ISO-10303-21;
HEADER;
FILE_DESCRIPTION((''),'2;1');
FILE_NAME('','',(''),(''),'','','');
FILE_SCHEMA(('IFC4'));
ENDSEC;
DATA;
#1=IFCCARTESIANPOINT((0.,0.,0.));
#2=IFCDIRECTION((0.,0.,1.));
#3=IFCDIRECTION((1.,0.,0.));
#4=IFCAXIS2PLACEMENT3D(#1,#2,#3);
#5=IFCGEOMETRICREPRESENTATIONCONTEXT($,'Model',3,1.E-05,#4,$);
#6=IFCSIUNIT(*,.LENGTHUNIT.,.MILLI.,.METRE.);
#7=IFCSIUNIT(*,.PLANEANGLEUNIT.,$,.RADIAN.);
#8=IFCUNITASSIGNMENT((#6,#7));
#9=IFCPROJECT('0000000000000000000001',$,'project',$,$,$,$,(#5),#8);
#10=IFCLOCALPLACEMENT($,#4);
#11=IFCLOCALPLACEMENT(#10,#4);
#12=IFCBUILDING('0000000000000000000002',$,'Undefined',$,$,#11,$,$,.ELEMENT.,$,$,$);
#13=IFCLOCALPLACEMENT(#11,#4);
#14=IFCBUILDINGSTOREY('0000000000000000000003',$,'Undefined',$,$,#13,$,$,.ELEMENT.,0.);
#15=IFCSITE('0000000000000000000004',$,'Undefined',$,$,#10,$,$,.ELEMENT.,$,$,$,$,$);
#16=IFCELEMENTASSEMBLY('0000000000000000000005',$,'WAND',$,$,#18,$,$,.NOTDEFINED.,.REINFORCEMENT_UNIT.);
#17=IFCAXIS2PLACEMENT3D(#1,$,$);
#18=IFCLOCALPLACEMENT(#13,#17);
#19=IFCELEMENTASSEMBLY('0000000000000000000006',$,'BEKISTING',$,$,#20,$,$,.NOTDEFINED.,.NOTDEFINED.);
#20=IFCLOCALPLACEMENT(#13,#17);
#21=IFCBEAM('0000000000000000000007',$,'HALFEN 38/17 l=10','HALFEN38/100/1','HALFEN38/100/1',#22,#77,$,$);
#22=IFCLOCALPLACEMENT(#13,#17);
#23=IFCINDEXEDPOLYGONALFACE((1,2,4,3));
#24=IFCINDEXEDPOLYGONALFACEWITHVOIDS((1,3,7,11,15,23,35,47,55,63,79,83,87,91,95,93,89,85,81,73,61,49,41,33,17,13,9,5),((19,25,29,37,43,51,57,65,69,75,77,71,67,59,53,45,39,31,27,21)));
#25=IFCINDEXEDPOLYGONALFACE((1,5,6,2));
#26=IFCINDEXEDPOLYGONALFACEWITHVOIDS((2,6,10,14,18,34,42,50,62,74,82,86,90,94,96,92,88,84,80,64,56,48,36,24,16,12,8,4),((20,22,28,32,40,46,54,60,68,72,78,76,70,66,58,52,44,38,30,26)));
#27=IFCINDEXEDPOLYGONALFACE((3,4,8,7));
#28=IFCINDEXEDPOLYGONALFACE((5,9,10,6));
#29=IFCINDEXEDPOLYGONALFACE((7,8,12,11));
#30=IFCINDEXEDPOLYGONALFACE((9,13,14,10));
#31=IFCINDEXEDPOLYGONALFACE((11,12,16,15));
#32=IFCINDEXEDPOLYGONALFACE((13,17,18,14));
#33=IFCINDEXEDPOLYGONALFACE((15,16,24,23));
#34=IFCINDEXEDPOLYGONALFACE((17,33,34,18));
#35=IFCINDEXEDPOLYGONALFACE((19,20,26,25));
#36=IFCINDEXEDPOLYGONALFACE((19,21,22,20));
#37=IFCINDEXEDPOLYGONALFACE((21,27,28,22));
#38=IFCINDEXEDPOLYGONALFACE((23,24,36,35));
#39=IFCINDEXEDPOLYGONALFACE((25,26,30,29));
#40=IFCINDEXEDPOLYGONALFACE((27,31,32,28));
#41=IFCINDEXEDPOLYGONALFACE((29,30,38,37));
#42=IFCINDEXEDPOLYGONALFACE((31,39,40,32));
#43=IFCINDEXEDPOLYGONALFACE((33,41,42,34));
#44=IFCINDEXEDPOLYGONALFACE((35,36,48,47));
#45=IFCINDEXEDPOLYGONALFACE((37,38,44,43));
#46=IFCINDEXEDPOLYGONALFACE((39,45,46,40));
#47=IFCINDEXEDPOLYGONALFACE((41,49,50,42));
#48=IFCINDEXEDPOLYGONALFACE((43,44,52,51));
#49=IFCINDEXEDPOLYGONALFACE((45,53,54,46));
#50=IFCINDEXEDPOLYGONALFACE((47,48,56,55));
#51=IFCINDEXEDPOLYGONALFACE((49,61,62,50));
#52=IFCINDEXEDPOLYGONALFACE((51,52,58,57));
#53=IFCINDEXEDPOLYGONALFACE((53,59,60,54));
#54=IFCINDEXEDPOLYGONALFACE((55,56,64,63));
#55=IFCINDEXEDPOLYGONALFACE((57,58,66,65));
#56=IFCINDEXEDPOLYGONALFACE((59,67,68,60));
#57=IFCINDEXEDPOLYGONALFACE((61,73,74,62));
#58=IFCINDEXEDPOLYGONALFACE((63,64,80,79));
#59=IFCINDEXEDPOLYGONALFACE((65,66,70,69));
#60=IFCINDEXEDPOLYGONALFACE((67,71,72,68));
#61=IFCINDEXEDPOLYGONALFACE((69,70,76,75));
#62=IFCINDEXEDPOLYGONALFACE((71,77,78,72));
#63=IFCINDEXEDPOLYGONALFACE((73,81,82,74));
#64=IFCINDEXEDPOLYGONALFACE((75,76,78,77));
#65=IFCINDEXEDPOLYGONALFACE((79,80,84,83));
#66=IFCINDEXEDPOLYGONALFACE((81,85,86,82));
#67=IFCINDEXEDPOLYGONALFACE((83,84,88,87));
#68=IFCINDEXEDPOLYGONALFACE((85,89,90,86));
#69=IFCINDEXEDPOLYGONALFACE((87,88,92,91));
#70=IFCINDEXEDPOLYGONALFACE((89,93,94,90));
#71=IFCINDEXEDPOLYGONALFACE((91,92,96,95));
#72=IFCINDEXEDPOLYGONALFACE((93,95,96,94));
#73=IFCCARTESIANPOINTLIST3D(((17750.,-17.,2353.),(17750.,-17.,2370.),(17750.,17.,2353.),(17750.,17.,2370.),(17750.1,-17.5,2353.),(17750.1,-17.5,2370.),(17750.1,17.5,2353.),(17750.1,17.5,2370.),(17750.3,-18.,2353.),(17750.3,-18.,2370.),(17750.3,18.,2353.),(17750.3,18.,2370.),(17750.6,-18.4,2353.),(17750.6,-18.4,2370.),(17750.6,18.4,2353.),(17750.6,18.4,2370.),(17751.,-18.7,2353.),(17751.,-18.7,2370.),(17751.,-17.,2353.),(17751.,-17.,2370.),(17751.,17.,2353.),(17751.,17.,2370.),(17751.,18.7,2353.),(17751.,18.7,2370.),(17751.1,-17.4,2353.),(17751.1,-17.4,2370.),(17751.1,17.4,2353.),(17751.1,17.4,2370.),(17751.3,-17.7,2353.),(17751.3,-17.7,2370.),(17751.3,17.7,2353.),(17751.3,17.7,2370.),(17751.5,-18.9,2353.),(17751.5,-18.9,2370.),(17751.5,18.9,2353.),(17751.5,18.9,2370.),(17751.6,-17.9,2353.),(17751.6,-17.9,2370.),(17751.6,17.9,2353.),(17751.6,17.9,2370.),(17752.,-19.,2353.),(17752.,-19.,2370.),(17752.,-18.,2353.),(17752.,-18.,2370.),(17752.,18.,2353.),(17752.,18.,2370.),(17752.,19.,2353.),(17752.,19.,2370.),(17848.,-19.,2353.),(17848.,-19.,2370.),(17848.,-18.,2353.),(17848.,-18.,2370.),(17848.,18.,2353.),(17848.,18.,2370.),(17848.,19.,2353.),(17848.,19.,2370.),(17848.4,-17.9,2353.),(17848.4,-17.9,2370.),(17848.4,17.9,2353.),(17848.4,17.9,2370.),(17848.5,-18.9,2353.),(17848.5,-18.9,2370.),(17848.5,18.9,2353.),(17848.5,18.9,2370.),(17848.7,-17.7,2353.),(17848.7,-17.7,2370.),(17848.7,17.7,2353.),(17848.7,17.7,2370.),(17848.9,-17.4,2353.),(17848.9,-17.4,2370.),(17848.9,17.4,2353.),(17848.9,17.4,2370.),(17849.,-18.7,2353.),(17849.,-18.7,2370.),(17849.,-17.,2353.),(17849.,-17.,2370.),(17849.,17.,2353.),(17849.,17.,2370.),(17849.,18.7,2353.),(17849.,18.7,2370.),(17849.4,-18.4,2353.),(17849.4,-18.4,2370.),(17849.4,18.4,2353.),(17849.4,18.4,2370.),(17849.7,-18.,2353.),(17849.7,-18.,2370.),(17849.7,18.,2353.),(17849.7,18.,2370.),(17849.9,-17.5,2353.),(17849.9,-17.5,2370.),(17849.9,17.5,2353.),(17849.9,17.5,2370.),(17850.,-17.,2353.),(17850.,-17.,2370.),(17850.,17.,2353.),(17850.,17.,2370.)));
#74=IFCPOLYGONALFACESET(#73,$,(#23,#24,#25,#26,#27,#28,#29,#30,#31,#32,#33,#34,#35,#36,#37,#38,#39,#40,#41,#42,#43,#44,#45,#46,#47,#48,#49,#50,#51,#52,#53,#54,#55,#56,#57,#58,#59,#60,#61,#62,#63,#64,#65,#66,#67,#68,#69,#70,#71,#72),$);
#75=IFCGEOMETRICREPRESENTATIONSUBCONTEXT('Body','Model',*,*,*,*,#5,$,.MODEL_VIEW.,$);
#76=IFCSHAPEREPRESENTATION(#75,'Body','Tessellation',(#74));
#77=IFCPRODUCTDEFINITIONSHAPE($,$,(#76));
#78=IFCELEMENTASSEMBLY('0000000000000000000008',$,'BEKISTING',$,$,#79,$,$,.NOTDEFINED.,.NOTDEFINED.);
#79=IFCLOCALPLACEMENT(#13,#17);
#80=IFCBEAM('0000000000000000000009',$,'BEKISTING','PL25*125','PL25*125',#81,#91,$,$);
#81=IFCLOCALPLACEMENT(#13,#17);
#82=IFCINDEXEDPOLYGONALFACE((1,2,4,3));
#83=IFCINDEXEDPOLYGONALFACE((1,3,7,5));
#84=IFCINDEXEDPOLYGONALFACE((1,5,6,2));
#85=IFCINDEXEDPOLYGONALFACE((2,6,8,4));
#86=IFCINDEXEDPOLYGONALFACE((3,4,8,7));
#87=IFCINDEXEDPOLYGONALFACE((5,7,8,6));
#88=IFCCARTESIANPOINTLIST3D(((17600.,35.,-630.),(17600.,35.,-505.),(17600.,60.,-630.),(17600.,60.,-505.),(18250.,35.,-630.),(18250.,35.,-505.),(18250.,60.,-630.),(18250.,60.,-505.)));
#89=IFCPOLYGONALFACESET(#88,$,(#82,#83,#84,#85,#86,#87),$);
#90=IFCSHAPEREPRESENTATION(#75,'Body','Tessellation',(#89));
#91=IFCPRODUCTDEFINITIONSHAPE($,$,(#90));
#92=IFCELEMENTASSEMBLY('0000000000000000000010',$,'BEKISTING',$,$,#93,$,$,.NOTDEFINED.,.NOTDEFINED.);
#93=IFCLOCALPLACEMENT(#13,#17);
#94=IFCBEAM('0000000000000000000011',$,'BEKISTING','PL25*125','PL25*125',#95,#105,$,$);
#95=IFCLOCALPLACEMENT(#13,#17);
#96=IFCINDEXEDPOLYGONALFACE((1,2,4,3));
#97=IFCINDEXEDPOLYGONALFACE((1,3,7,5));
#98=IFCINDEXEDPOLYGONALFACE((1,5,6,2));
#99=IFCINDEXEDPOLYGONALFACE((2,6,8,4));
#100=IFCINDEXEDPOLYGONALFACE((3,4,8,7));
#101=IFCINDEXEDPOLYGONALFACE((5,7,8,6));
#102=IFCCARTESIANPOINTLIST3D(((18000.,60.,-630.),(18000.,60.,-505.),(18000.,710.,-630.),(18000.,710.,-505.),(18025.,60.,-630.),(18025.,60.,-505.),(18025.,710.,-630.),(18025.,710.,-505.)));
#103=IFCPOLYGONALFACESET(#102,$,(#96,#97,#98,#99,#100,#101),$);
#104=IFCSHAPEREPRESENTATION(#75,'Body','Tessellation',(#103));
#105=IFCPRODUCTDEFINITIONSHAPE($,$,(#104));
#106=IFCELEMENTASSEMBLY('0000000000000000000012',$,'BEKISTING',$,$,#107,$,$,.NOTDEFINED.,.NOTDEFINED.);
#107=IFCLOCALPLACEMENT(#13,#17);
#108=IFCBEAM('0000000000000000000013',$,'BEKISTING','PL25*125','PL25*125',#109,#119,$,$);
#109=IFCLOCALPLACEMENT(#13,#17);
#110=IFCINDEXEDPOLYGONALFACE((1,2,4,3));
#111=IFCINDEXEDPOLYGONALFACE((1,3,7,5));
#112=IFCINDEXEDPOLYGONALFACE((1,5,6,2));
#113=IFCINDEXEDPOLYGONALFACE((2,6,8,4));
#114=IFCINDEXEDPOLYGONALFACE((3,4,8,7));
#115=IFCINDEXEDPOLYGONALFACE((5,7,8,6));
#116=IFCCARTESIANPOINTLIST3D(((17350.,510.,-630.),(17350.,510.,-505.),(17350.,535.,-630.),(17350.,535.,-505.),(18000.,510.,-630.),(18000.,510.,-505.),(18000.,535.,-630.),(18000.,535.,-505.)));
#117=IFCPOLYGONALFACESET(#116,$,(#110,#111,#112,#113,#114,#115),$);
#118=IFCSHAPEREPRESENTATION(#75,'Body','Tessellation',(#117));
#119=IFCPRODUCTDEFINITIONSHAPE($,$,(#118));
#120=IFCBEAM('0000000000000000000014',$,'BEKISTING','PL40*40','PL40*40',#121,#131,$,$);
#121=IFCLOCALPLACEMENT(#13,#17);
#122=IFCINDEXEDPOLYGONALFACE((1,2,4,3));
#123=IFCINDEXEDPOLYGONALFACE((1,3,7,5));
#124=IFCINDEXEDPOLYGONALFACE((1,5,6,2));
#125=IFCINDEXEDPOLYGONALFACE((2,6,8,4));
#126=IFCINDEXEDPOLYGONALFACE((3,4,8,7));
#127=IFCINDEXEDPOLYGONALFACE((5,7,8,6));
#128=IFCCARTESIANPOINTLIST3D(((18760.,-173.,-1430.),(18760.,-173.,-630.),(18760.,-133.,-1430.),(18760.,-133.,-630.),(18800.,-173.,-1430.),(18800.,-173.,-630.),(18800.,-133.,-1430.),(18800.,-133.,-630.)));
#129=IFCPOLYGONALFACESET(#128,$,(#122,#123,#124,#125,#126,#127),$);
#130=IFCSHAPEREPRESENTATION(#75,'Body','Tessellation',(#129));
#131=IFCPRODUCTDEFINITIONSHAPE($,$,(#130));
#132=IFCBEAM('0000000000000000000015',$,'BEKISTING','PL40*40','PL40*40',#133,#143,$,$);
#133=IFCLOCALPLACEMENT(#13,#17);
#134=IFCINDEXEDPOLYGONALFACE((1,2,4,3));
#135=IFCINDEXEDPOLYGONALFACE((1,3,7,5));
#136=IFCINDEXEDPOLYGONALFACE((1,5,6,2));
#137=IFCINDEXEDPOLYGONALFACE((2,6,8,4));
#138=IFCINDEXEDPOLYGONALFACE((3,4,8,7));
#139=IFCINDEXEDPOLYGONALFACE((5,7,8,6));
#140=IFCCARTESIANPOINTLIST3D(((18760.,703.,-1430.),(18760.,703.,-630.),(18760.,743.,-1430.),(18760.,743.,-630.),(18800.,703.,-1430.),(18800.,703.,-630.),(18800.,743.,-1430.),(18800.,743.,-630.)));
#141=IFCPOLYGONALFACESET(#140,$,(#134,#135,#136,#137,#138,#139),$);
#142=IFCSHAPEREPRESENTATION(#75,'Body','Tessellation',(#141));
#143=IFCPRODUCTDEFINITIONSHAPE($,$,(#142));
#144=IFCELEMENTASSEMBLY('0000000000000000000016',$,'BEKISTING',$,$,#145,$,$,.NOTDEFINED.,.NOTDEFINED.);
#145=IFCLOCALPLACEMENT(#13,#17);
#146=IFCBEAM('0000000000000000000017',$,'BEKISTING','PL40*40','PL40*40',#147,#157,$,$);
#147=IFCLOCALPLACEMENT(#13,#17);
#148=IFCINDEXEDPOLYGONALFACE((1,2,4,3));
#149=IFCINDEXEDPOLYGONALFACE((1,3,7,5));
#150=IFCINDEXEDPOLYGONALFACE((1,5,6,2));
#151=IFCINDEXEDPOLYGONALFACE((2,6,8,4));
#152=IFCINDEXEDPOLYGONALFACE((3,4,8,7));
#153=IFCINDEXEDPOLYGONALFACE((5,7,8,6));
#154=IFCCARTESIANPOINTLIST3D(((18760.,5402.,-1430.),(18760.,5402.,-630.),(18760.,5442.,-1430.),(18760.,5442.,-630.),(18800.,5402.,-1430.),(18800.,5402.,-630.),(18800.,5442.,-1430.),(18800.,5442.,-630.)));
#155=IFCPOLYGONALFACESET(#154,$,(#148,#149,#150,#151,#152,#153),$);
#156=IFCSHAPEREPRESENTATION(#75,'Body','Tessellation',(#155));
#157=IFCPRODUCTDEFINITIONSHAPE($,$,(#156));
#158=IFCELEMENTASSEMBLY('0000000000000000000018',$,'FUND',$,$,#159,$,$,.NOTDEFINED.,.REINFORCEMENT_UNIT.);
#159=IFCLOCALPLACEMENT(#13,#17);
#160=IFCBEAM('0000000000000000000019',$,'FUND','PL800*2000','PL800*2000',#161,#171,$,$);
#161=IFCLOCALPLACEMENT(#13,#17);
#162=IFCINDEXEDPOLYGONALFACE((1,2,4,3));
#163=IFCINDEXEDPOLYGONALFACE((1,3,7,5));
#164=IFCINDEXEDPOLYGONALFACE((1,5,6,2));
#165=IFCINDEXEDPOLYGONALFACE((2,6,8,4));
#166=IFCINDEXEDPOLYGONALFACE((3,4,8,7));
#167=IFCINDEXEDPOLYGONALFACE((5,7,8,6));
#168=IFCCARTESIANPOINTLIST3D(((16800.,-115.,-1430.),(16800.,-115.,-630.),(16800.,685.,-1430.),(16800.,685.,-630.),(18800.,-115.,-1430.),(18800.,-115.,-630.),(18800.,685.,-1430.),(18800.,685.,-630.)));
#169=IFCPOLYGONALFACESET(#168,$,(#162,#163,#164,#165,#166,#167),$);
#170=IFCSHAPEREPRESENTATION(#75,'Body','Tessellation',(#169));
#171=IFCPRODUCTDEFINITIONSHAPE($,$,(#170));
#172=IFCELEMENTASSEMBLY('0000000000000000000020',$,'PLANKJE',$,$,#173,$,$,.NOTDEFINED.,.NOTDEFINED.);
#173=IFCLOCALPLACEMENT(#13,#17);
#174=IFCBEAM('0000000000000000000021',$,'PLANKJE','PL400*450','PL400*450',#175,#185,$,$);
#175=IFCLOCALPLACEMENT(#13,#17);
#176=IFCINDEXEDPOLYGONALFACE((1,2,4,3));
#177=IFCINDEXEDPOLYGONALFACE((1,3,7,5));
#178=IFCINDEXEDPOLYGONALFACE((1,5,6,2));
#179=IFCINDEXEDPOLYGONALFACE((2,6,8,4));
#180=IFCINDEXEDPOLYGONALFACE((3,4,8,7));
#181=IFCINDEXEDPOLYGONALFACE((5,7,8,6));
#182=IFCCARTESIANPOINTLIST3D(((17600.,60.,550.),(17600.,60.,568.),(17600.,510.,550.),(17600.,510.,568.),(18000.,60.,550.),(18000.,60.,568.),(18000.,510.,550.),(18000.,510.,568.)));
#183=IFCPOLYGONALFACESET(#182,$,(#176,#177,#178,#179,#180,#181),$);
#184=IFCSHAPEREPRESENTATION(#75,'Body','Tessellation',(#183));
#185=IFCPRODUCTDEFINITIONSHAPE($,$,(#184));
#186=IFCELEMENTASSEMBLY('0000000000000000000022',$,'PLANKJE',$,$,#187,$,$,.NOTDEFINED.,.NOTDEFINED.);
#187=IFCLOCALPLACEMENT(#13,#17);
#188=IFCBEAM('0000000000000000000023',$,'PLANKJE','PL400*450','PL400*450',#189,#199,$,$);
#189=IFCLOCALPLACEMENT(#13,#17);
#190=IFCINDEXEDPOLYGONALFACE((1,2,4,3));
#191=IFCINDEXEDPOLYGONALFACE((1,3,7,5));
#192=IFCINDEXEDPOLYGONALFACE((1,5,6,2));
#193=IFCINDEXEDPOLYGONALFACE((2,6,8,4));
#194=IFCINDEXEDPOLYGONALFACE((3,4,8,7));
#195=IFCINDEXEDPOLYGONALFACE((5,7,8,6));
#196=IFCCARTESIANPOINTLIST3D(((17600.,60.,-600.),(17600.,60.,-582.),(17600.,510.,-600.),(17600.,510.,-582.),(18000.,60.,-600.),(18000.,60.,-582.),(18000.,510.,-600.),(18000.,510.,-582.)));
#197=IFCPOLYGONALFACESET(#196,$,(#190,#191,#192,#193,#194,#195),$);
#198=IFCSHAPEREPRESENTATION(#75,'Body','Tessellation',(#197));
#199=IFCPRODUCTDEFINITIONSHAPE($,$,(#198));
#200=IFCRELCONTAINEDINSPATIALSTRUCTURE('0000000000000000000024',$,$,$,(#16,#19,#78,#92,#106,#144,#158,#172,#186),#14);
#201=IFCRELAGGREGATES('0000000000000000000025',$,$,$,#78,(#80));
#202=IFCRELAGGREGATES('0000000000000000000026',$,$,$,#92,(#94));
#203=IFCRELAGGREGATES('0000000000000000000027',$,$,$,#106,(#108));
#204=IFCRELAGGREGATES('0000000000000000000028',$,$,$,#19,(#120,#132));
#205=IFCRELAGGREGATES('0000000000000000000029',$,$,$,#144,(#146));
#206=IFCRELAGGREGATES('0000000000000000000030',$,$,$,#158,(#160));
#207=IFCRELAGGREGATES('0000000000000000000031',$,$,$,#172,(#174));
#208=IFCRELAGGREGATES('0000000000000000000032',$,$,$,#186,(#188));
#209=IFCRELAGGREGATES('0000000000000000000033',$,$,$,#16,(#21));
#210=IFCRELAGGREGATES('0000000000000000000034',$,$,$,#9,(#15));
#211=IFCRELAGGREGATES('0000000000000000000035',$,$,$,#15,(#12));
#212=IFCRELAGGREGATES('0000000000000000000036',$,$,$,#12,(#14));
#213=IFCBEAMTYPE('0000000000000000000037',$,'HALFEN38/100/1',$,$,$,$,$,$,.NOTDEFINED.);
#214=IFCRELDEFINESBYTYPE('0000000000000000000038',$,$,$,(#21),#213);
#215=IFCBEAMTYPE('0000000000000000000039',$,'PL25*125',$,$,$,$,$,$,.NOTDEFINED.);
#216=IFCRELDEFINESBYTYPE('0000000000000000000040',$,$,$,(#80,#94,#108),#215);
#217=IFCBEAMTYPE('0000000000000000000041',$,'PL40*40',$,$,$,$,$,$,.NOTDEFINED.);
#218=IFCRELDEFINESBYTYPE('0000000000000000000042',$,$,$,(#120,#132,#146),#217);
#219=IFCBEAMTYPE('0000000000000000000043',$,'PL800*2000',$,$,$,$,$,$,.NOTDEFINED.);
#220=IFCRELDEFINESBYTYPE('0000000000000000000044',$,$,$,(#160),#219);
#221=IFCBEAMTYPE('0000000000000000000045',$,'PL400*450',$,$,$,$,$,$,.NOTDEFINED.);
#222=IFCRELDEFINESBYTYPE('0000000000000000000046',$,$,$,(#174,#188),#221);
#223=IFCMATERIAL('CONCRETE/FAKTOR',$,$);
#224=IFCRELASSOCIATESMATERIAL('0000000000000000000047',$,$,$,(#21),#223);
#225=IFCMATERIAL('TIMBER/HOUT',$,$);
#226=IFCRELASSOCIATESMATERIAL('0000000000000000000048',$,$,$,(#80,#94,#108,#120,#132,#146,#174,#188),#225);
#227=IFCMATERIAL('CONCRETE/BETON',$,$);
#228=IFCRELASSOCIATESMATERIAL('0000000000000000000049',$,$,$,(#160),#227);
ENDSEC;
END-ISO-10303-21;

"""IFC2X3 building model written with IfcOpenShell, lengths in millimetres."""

from ifc_helpers import new_model, si_unit, frame, frame_2d, origin_with_axes, place, context, subcontext, project, spatial, rectangle, hollow_rectangle, extrude, material, type_object, element, aggregate, save


model = new_model("IFC2X3")

# Units and contexts
model_context = context("Model", 3, precision=1e-05, world=origin_with_axes())
body_context = subcontext(model_context, "Body", "Model", "MODEL_VIEW")
ifc_project = project(units=[si_unit("LENGTHUNIT", "METRE", prefix="MILLI"), si_unit("PLANEANGLEUNIT", "RADIAN")], contexts=[model_context])

# Site, building, storey
site_placement = place(None, origin_with_axes())
site = spatial("IfcSite", under=ifc_project, at=site_placement, Name="Undefined", CompositionType="ELEMENT")
building_placement = place(site_placement, origin_with_axes())
building = spatial("IfcBuilding", under=site, at=building_placement, Name="Undefined", CompositionType="ELEMENT")
storey_placement = place(building_placement, origin_with_axes())
storey = spatial("IfcBuildingStorey", under=building, at=storey_placement, Name="Undefined", CompositionType="ELEMENT", Elevation=0.0)

# Element assembly
ifc_material_1 = material(Name="CONCRETE/FAKTOR")
assembly_1_placement = place(storey_placement, origin_with_axes())
assembly_1 = element("IfcElementAssembly", 1, at=assembly_1_placement, inside=storey, Name="WAND", AssemblyPlace="NOTDEFINED", PredefinedType="REINFORCEMENT_UNIT")
ifc_material_2 = material(Name="CONCRETE/BETON")

# Element assembly
ifc_material_3 = material(Name="TIMBER/HOUT")
assembly_2_placement = place(storey_placement, origin_with_axes())
assembly_2 = element("IfcElementAssembly", 2, at=assembly_2_placement, inside=storey, Name="BEKISTING", AssemblyPlace="NOTDEFINED", PredefinedType="NOTDEFINED")

# Beam
beam_type_1 = type_object("IfcBeamType", Name="HALFEN38/100/1", PredefinedType="NOTDEFINED")
beam_1_placement = place(assembly_1_placement, frame((17800.0, 0.0, 2370.0), z_axis=(0.0, -1.0, 0.0), x_axis=(0.0, 0.0, -1.0)))
beam_1 = element("IfcBeam", 3, at=beam_1_placement, type_object=beam_type_1, material=ifc_material_1, Name="HALFEN 38/17 l=10", Description="HALFEN38/100/1", ObjectType="HALFEN38/100/1", context=body_context, shape_type="SweptSolid", body=[
    extrude(hollow_rectangle(XDim=100.0, YDim=38.0, WallThickness=1.0, InnerFilletRadius=1.0, OuterFilletRadius=2.0, at=frame_2d((0.0, 0.0), x_axis=(1.0, 0.0))), frame((17.0, 0.0, 0.0), z_axis=(-1.0, 0.0, 0.0), x_axis=(0.0, -1.0, 0.0)), (0.0, 0.0, 1.0), 17.0),
])

# Element assemblies, beams
assembly_3_placement = place(storey_placement, origin_with_axes())
assembly_3 = element("IfcElementAssembly", 4, at=assembly_3_placement, inside=storey, Name="BEKISTING", AssemblyPlace="NOTDEFINED", PredefinedType="NOTDEFINED")
beam_type_2 = type_object("IfcBeamType", Name="PL25*125", PredefinedType="NOTDEFINED")
beam_2_placement = place(assembly_3_placement, frame((18250.0, 47.5, -567.5), z_axis=(0.0, 0.0, -1.0), x_axis=(-1.0, 0.0, 0.0)))
beam_2 = element("IfcBeam", 5, at=beam_2_placement, type_object=beam_type_2, material=ifc_material_3, Name="BEKISTING", Description="PL25*125", ObjectType="PL25*125", context=body_context, shape_type="SweptSolid", body=[
    extrude(rectangle(XDim=25.0, YDim=125.0, at=frame_2d((0.0, 0.0), x_axis=(1.0, 0.0))), frame((650.0, 0.0, 0.0), z_axis=(-1.0, 0.0, 0.0), x_axis=(0.0, -1.0, 0.0)), (0.0, 0.0, 1.0), 650.0),
])
aggregate(assembly_3, [beam_2])
assembly_4_placement = place(storey_placement, origin_with_axes())
assembly_4 = element("IfcElementAssembly", 6, at=assembly_4_placement, inside=storey, Name="BEKISTING", AssemblyPlace="NOTDEFINED", PredefinedType="NOTDEFINED")
beam_3_placement = place(assembly_4_placement, frame((18012.5, 60.0, -567.5), z_axis=(0.0, 0.0, -1.0), x_axis=(0.0, 1.0, 0.0)))
beam_3 = element("IfcBeam", 7, at=beam_3_placement, type_object=beam_type_2, material=ifc_material_3, Name="BEKISTING", Description="PL25*125", ObjectType="PL25*125", context=body_context, shape_type="SweptSolid", body=[
    extrude(rectangle(XDim=25.0, YDim=125.0, at=frame_2d((0.0, 0.0), x_axis=(1.0, 0.0))), frame((650.0, 0.0, 0.0), z_axis=(-1.0, 0.0, 0.0), x_axis=(0.0, -1.0, 0.0)), (0.0, 0.0, 1.0), 650.0),
])
aggregate(assembly_4, [beam_3])
assembly_5_placement = place(storey_placement, origin_with_axes())
assembly_5 = element("IfcElementAssembly", 8, at=assembly_5_placement, inside=storey, Name="BEKISTING", AssemblyPlace="NOTDEFINED", PredefinedType="NOTDEFINED")
beam_4_placement = place(assembly_5_placement, frame((18000.0, 522.5, -567.5), z_axis=(0.0, 0.0, -1.0), x_axis=(-1.0, 0.0, 0.0)))
beam_4 = element("IfcBeam", 9, at=beam_4_placement, type_object=beam_type_2, material=ifc_material_3, Name="BEKISTING", Description="PL25*125", ObjectType="PL25*125", context=body_context, shape_type="SweptSolid", body=[
    extrude(rectangle(XDim=25.0, YDim=125.0, at=frame_2d((0.0, 0.0), x_axis=(1.0, 0.0))), frame((650.0, 0.0, 0.0), z_axis=(-1.0, 0.0, 0.0), x_axis=(0.0, -1.0, 0.0)), (0.0, 0.0, 1.0), 650.0),
])
aggregate(assembly_5, [beam_4])

# Beams
beam_type_3 = type_object("IfcBeamType", Name="PL40*40", PredefinedType="NOTDEFINED")
beam_5_placement = place(assembly_2_placement, frame((18780.0, -153.0, -1430.0), z_axis=(0.0, 1.0, 0.0), x_axis=(0.0, 0.0, 1.0)))
beam_5 = element("IfcBeam", 10, at=beam_5_placement, type_object=beam_type_3, material=ifc_material_3, Name="BEKISTING", Description="PL40*40", ObjectType="PL40*40", context=body_context, shape_type="SweptSolid", body=[
    extrude(rectangle(XDim=40.0, YDim=40.0, at=frame_2d((0.0, 0.0), x_axis=(1.0, 0.0))), frame((800.0, 0.0, 0.0), z_axis=(-1.0, 0.0, 0.0), x_axis=(0.0, -1.0, 0.0)), (0.0, 0.0, 1.0), 800.0),
])
beam_6_placement = place(assembly_2_placement, frame((18780.0, 723.0, -1430.0), z_axis=(0.0, 1.0, 0.0), x_axis=(0.0, 0.0, 1.0)))
beam_6 = element("IfcBeam", 11, at=beam_6_placement, type_object=beam_type_3, material=ifc_material_3, Name="BEKISTING", Description="PL40*40", ObjectType="PL40*40", context=body_context, shape_type="SweptSolid", body=[
    extrude(rectangle(XDim=40.0, YDim=40.0, at=frame_2d((0.0, 0.0), x_axis=(1.0, 0.0))), frame((800.0, 0.0, 0.0), z_axis=(-1.0, 0.0, 0.0), x_axis=(0.0, -1.0, 0.0)), (0.0, 0.0, 1.0), 800.0),
])
aggregate(assembly_2, [beam_5, beam_6])

# Element assemblies, beams
assembly_6_placement = place(storey_placement, origin_with_axes())
assembly_6 = element("IfcElementAssembly", 12, at=assembly_6_placement, inside=storey, Name="BEKISTING", AssemblyPlace="NOTDEFINED", PredefinedType="NOTDEFINED")
beam_7_placement = place(assembly_6_placement, frame((18780.0, 5422.0, -1430.0), z_axis=(0.0, 1.0, 0.0), x_axis=(0.0, 0.0, 1.0)))
beam_7 = element("IfcBeam", 13, at=beam_7_placement, type_object=beam_type_3, material=ifc_material_3, Name="BEKISTING", Description="PL40*40", ObjectType="PL40*40", context=body_context, shape_type="SweptSolid", body=[
    extrude(rectangle(XDim=40.0, YDim=40.0, at=frame_2d((0.0, 0.0), x_axis=(1.0, 0.0))), frame((800.0, 0.0, 0.0), z_axis=(-1.0, 0.0, 0.0), x_axis=(0.0, -1.0, 0.0)), (0.0, 0.0, 1.0), 800.0),
])
aggregate(assembly_6, [beam_7])
assembly_7_placement = place(storey_placement, origin_with_axes())
assembly_7 = element("IfcElementAssembly", 14, at=assembly_7_placement, inside=storey, Name="FUND", AssemblyPlace="NOTDEFINED", PredefinedType="REINFORCEMENT_UNIT")
beam_type_4 = type_object("IfcBeamType", Name="PL800*2000", PredefinedType="NOTDEFINED")
beam_8_placement = place(assembly_7_placement, frame((17800.0, 285.0, -630.0), z_axis=(-1.0, 0.0, 0.0), x_axis=(0.0, 0.0, -1.0)))
beam_8 = element("IfcBeam", 15, at=beam_8_placement, type_object=beam_type_4, material=ifc_material_2, Name="FUND", Description="PL800*2000", ObjectType="PL800*2000", context=body_context, shape_type="SweptSolid", body=[
    extrude(rectangle(XDim=800.0, YDim=2000.0, at=frame_2d((0.0, 0.0), x_axis=(1.0, 0.0))), frame((800.0, 0.0, 0.0), z_axis=(-1.0, 0.0, 0.0), x_axis=(0.0, -1.0, 0.0)), (0.0, 0.0, 1.0), 800.0),
])
aggregate(assembly_7, [beam_8])
assembly_8_placement = place(storey_placement, origin_with_axes())
assembly_8 = element("IfcElementAssembly", 16, at=assembly_8_placement, inside=storey, Name="PLANKJE", AssemblyPlace="NOTDEFINED", PredefinedType="NOTDEFINED")
beam_type_5 = type_object("IfcBeamType", Name="PL400*450", PredefinedType="NOTDEFINED")
beam_9_placement = place(assembly_8_placement, frame((17800.0, 285.0, 550.0), z_axis=(0.0, 1.0, 0.0), x_axis=(0.0, 0.0, 1.0)))
beam_9 = element("IfcBeam", 17, at=beam_9_placement, type_object=beam_type_5, material=ifc_material_3, Name="PLANKJE", Description="PL400*450", ObjectType="PL400*450", context=body_context, shape_type="SweptSolid", body=[
    extrude(rectangle(XDim=400.0, YDim=450.0, at=frame_2d((0.0, 0.0), x_axis=(1.0, 0.0))), frame((18.0, 0.0, 0.0), z_axis=(-1.0, 0.0, 0.0), x_axis=(0.0, -1.0, 0.0)), (0.0, 0.0, 1.0), 18.0),
])
aggregate(assembly_8, [beam_9])
assembly_9_placement = place(storey_placement, origin_with_axes())
assembly_9 = element("IfcElementAssembly", 18, at=assembly_9_placement, inside=storey, Name="PLANKJE", AssemblyPlace="NOTDEFINED", PredefinedType="NOTDEFINED")
beam_10_placement = place(assembly_9_placement, frame((17800.0, 285.0, -600.0), z_axis=(0.0, 1.0, 0.0), x_axis=(0.0, 0.0, 1.0)))
beam_10 = element("IfcBeam", 19, at=beam_10_placement, type_object=beam_type_5, material=ifc_material_3, Name="PLANKJE", Description="PL400*450", ObjectType="PL400*450", context=body_context, shape_type="SweptSolid", body=[
    extrude(rectangle(XDim=400.0, YDim=450.0, at=frame_2d((0.0, 0.0), x_axis=(1.0, 0.0))), frame((18.0, 0.0, 0.0), z_axis=(-1.0, 0.0, 0.0), x_axis=(0.0, -1.0, 0.0)), (0.0, 0.0, 1.0), 18.0),
])
aggregate(assembly_9, [beam_10])

aggregate(assembly_1, [beam_1])

save(model, "model.ifc")
